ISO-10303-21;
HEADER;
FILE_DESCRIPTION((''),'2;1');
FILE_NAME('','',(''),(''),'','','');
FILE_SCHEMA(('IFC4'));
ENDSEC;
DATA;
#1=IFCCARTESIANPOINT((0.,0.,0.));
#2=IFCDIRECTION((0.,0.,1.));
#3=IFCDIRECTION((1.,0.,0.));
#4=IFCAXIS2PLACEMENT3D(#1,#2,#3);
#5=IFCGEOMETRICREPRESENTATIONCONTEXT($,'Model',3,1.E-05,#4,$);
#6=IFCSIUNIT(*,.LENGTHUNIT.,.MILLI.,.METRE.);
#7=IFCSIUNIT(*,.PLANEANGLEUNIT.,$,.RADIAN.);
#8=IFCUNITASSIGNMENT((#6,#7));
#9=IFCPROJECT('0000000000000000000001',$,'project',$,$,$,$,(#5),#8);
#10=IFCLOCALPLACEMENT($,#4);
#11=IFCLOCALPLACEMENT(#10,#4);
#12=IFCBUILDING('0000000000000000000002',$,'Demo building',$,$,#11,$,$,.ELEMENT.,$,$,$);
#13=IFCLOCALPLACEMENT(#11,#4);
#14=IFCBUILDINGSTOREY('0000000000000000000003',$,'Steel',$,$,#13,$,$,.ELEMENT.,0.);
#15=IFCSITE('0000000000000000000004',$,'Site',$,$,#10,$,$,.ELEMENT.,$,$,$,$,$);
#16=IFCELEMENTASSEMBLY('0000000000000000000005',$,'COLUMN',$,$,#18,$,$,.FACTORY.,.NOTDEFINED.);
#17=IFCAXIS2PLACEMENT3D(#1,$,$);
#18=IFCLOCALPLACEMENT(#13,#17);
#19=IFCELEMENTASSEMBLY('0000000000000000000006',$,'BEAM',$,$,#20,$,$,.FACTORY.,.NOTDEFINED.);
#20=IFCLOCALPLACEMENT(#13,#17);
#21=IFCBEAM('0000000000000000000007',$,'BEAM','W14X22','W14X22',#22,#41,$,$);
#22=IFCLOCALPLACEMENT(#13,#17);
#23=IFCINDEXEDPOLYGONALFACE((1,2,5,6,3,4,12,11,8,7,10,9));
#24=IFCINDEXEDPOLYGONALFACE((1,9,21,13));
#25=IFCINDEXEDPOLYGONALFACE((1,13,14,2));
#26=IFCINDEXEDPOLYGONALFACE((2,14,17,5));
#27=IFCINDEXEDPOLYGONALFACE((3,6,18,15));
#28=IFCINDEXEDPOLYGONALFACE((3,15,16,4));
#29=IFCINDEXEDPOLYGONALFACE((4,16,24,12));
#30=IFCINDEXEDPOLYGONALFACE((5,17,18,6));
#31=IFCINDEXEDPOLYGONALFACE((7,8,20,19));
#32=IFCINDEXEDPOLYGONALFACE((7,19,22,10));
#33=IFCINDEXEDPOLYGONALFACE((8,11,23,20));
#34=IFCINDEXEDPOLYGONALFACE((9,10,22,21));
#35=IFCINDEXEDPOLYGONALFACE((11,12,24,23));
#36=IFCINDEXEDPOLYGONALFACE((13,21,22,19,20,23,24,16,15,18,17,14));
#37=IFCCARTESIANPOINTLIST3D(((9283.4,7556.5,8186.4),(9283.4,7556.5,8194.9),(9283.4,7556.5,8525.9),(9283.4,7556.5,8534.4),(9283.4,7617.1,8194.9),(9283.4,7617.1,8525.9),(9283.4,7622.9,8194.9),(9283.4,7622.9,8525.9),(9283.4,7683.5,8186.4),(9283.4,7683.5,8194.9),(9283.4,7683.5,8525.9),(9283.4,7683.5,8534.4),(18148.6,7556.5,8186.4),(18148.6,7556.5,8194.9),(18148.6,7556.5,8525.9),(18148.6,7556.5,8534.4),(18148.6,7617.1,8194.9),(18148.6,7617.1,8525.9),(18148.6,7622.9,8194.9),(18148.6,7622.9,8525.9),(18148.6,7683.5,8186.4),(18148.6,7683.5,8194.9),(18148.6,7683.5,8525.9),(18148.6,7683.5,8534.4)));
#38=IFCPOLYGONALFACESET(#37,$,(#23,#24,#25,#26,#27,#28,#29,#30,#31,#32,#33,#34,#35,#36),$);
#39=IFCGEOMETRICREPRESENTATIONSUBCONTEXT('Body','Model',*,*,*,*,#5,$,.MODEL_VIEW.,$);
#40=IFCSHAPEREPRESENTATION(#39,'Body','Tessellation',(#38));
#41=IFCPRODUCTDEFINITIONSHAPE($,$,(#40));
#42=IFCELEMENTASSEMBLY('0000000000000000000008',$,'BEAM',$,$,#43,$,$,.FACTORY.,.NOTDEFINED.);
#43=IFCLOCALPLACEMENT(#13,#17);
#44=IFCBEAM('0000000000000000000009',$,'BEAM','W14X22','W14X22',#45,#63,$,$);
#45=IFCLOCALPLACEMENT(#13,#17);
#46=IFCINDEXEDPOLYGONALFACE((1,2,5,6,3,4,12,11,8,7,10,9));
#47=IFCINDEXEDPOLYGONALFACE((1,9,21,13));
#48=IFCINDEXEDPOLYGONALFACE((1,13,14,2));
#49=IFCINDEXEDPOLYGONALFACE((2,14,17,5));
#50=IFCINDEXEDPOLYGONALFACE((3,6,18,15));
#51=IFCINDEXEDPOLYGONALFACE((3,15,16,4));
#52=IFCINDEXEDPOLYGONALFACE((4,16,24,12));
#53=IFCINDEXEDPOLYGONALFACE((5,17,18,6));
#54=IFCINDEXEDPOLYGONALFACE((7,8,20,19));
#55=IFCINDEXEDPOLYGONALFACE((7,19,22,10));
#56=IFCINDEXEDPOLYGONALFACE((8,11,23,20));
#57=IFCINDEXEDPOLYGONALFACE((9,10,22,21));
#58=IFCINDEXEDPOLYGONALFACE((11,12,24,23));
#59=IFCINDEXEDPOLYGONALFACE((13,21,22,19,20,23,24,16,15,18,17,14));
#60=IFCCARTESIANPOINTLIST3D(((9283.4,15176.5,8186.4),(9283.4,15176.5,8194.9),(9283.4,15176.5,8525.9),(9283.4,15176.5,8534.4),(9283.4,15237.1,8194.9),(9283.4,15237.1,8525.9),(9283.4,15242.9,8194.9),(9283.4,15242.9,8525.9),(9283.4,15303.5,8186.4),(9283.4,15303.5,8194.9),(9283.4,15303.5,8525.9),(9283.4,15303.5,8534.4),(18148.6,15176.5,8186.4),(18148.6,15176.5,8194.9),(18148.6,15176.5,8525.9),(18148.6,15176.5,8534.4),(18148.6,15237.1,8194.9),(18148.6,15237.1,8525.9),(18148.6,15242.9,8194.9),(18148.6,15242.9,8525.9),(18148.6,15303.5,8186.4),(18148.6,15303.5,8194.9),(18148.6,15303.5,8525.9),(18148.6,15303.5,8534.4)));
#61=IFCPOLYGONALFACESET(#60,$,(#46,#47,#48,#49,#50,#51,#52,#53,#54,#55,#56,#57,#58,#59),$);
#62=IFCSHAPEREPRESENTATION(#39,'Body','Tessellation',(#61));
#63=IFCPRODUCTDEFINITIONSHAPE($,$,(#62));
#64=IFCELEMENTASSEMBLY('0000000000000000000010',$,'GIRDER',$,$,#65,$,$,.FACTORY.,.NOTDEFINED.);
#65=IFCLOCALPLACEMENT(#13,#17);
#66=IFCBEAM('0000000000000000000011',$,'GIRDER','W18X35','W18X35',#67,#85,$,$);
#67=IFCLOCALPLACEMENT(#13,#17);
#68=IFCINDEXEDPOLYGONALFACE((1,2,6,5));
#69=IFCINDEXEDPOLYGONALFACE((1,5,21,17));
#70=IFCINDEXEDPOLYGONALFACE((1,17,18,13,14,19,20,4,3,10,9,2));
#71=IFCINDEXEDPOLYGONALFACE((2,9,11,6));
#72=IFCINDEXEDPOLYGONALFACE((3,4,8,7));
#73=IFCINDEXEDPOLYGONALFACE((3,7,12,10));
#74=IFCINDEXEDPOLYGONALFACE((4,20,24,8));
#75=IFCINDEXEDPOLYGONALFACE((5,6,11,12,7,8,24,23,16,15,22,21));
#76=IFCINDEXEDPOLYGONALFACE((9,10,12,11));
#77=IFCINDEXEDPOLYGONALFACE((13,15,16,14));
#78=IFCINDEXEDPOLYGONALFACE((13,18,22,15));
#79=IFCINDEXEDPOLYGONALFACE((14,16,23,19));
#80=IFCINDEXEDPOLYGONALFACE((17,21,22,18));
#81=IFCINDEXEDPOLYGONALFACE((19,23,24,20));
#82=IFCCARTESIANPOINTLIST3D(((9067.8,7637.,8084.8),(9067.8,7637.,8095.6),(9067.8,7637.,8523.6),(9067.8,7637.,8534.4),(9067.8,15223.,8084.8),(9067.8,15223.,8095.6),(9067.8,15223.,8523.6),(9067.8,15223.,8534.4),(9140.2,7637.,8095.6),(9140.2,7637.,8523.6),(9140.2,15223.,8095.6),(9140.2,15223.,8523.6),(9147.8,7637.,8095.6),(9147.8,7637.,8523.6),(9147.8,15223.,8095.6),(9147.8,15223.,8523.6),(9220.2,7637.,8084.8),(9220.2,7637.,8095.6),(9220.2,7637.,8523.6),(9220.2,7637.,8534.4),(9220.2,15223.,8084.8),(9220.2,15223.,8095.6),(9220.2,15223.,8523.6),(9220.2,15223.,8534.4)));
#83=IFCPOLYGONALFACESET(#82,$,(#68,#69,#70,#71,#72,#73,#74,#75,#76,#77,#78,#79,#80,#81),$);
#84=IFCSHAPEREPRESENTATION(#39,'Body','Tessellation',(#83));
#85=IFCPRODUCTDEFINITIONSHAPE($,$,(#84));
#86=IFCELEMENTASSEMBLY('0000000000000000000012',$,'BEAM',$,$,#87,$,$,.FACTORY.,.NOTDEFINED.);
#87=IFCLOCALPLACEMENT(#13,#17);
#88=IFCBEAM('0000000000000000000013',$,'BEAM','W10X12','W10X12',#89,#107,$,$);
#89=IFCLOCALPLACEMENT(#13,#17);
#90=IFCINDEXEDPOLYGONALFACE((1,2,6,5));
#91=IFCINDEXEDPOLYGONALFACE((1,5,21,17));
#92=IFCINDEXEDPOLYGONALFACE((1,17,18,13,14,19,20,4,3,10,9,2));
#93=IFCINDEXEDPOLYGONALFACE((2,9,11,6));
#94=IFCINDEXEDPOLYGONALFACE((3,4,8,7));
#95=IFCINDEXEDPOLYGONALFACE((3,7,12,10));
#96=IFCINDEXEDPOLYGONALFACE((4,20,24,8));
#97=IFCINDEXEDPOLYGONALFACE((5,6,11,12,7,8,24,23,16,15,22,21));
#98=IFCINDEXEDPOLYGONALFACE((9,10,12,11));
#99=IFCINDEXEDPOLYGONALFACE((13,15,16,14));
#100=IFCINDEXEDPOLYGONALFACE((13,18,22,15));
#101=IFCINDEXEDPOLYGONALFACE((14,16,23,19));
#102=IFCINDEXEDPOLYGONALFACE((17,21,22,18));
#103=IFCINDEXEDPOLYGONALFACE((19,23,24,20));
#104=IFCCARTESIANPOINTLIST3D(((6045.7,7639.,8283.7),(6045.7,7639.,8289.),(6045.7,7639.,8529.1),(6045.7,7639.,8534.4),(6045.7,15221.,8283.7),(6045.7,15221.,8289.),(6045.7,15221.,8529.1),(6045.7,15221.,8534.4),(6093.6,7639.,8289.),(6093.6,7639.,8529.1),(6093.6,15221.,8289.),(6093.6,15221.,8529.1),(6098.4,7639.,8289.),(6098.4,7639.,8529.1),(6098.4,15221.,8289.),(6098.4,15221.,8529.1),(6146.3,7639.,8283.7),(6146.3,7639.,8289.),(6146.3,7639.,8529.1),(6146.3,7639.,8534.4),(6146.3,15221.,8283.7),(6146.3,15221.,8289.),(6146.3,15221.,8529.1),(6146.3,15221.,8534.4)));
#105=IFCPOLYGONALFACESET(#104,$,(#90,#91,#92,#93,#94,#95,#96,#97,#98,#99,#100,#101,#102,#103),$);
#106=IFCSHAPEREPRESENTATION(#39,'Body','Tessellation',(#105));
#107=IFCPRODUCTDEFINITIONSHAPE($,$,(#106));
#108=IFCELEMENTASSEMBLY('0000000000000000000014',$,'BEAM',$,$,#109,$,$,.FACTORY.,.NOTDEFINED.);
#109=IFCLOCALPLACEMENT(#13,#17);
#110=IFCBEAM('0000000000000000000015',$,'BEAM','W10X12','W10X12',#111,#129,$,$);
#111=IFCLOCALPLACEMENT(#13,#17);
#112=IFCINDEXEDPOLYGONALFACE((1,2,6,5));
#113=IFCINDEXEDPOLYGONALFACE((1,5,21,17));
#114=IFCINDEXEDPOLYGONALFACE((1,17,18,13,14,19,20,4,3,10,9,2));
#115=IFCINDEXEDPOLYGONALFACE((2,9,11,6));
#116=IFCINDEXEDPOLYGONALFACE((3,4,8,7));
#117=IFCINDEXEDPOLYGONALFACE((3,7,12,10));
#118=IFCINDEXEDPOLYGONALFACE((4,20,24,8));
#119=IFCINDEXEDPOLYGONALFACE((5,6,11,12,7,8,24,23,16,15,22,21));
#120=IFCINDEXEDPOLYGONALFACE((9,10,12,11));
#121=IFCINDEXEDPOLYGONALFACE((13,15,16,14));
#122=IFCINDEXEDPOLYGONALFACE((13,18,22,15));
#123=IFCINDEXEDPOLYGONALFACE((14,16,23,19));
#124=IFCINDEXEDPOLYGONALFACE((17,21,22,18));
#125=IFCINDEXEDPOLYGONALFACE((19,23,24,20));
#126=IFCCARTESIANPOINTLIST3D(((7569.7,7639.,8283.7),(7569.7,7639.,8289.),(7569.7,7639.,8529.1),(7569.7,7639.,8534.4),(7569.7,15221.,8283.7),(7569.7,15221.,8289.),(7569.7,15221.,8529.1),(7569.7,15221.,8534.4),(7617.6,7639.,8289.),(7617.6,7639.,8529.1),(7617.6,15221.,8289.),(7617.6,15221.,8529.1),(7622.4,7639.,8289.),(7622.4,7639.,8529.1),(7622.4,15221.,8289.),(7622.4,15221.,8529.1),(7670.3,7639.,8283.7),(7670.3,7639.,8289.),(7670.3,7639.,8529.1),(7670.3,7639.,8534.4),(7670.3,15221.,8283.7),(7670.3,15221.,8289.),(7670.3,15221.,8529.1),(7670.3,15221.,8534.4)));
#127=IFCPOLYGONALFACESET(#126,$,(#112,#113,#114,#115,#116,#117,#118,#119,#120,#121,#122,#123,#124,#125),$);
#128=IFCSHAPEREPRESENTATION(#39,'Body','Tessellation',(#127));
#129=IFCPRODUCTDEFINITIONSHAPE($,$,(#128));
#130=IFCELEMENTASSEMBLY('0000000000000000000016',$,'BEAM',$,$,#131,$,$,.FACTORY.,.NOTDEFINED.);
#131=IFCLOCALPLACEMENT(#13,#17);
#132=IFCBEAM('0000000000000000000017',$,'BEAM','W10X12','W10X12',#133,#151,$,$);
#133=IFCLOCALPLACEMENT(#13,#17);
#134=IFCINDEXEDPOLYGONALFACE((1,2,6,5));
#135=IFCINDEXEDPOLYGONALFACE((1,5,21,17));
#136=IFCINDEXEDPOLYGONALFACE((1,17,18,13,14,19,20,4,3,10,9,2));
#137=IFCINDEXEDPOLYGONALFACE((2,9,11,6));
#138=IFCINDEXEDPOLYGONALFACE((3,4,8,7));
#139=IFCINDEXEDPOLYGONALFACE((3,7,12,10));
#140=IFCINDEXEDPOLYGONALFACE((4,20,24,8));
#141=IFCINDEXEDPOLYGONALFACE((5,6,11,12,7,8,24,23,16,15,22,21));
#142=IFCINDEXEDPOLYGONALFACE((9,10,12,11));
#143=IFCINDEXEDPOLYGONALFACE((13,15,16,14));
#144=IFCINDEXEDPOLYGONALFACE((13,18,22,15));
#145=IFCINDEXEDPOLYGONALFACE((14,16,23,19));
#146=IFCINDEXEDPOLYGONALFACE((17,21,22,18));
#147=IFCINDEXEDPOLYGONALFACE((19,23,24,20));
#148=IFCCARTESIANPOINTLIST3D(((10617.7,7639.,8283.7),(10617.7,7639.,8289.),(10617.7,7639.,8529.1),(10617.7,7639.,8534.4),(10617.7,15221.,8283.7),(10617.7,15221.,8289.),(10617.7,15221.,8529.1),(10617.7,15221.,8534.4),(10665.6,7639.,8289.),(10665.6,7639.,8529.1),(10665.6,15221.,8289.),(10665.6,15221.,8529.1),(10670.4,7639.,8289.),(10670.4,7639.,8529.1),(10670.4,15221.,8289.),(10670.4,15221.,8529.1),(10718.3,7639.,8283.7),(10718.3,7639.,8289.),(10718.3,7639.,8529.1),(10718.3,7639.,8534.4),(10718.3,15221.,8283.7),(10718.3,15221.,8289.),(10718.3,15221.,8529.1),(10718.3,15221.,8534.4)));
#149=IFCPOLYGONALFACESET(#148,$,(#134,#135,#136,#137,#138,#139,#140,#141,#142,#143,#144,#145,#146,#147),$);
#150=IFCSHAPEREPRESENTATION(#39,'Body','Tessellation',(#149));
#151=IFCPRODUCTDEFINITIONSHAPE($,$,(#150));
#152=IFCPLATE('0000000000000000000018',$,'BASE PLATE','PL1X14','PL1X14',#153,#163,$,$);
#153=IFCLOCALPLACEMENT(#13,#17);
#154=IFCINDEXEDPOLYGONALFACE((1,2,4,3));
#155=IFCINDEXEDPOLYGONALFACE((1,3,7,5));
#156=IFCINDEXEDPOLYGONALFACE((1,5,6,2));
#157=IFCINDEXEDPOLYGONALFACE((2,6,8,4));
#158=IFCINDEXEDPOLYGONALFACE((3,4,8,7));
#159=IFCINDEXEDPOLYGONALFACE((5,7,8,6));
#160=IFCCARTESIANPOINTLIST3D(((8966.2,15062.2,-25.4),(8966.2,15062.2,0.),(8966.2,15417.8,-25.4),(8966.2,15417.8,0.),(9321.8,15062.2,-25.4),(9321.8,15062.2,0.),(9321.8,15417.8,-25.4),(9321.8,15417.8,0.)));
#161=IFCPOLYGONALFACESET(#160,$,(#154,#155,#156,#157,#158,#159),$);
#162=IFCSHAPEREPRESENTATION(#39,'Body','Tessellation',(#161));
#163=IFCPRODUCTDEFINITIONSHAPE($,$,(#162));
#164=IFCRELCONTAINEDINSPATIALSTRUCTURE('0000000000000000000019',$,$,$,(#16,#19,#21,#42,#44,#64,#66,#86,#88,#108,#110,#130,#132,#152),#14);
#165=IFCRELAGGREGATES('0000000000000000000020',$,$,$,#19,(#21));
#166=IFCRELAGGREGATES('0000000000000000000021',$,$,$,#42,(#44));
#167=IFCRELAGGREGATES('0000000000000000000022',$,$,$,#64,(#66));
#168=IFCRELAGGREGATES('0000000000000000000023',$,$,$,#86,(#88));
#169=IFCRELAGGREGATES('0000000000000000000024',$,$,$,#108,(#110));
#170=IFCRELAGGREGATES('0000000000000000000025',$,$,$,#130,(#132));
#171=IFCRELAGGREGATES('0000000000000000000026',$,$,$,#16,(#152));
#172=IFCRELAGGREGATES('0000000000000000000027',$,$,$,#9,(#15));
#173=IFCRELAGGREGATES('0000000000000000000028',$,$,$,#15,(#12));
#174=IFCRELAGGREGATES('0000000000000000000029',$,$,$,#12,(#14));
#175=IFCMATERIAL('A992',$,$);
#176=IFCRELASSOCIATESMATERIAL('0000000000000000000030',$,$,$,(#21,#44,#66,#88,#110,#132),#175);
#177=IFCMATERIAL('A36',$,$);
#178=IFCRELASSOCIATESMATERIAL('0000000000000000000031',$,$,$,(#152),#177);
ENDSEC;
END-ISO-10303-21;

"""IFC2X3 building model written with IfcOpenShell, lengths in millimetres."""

from ifc_helpers import new_model, si_unit, frame, frame_2d, origin, origin_with_axes, origin_2d, place, context, subcontext, project, spatial, rectangle, i_section, extrude, material, element, aggregate, save


model = new_model("IFC2X3")

# Units and contexts
model_context = context("Model", 3, precision=1e-05, world=origin_with_axes())
body_context = subcontext(model_context, "Body", "Model", "MODEL_VIEW")
ifc_project = project(units=[si_unit("LENGTHUNIT", "METRE", prefix="MILLI"), si_unit("PLANEANGLEUNIT", "RADIAN")], contexts=[model_context])

# Site, building, storey
site_placement = place(None, origin_with_axes())
site = spatial("IfcSite", under=ifc_project, at=site_placement, Name="Site", CompositionType="ELEMENT")
building_placement = place(site_placement, origin_with_axes())
building = spatial("IfcBuilding", under=site, at=building_placement, Name="Demo building", CompositionType="ELEMENT")
placement = place(building_placement, origin_with_axes())
storey = spatial("IfcBuildingStorey", under=building, at=placement, Name="Steel", CompositionType="ELEMENT", Elevation=0.0)

# Element assembly
ifc_material_1 = material(Name="A992")
assembly_1 = element("IfcElementAssembly", 1, at=placement, inside=storey, Name="COLUMN", AssemblyPlace="FACTORY", PredefinedType="NOTDEFINED")

# Element assemblies, beams
assembly_2 = element("IfcElementAssembly", 2, at=placement, inside=storey, Name="BEAM", AssemblyPlace="FACTORY", PredefinedType="NOTDEFINED")
beam_1_placement = place(placement, frame((9283.4, 7620.0, 8360.4), z_axis=(1.0, 0.0, 0.0), x_axis=(0.0, 1.0, 0.0)))
beam_1 = element("IfcBeam", 3, at=beam_1_placement, inside=storey, material=ifc_material_1, Name="BEAM", Description="W14X22", ObjectType="W14X22", context=body_context, shape_type="SweptSolid", body=[
    extrude(i_section(OverallWidth=127.0, OverallDepth=348.0, WebThickness=5.8, FlangeThickness=8.5, at=origin_2d()), origin(), (0.0, 0.0, 1.0), 8865.1),
])
aggregate(assembly_2, [beam_1])
assembly_3 = element("IfcElementAssembly", 4, at=placement, inside=storey, Name="BEAM", AssemblyPlace="FACTORY", PredefinedType="NOTDEFINED")
beam_2_placement = place(placement, frame((9283.4, 15240.0, 8360.4), z_axis=(1.0, 0.0, 0.0), x_axis=(0.0, 1.0, 0.0)))
beam_2 = element("IfcBeam", 5, at=beam_2_placement, inside=storey, material=ifc_material_1, Name="BEAM", Description="W14X22", ObjectType="W14X22", context=body_context, shape_type="SweptSolid", body=[
    extrude(i_section(OverallWidth=127.0, OverallDepth=348.0, WebThickness=5.8, FlangeThickness=8.5, at=origin_2d()), origin(), (0.0, 0.0, 1.0), 8865.1),
])
aggregate(assembly_3, [beam_2])
assembly_4 = element("IfcElementAssembly", 6, at=placement, inside=storey, Name="GIRDER", AssemblyPlace="FACTORY", PredefinedType="NOTDEFINED")
beam_3_placement = place(placement, frame((9144.0, 7637.0, 8309.6), z_axis=(0.0, 1.0, 0.0), x_axis=(-1.0, 0.0, 0.0)))
beam_3 = element("IfcBeam", 7, at=beam_3_placement, inside=storey, material=ifc_material_1, Name="GIRDER", Description="W18X35", ObjectType="W18X35", context=body_context, shape_type="SweptSolid", body=[
    extrude(i_section(OverallWidth=152.4, OverallDepth=449.6, WebThickness=7.6, FlangeThickness=10.8, at=origin_2d()), origin(), (0.0, 0.0, 1.0), 7586.0),
])
aggregate(assembly_4, [beam_3])
assembly_5 = element("IfcElementAssembly", 8, at=placement, inside=storey, Name="BEAM", AssemblyPlace="FACTORY", PredefinedType="NOTDEFINED")
beam_4_placement = place(placement, frame((6096.0, 7639.1, 8409.1), z_axis=(0.0, 1.0, 0.0), x_axis=(-1.0, 0.0, 0.0)))
beam_4 = element("IfcBeam", 9, at=beam_4_placement, inside=storey, material=ifc_material_1, Name="BEAM", Description="W10X12", ObjectType="W10X12", context=body_context, shape_type="SweptSolid", body=[
    extrude(i_section(OverallWidth=100.6, OverallDepth=250.7, WebThickness=4.8, FlangeThickness=5.3, at=origin_2d()), origin(), (0.0, 0.0, 1.0), 7581.9),
])
aggregate(assembly_5, [beam_4])
assembly_6 = element("IfcElementAssembly", 10, at=placement, inside=storey, Name="BEAM", AssemblyPlace="FACTORY", PredefinedType="NOTDEFINED")
beam_5_placement = place(placement, frame((7620.0, 7639.1, 8409.1), z_axis=(0.0, 1.0, 0.0), x_axis=(-1.0, 0.0, 0.0)))
beam_5 = element("IfcBeam", 11, at=beam_5_placement, inside=storey, material=ifc_material_1, Name="BEAM", Description="W10X12", ObjectType="W10X12", context=body_context, shape_type="SweptSolid", body=[
    extrude(i_section(OverallWidth=100.6, OverallDepth=250.7, WebThickness=4.8, FlangeThickness=5.3, at=origin_2d()), origin(), (0.0, 0.0, 1.0), 7581.9),
])
aggregate(assembly_6, [beam_5])
assembly_7 = element("IfcElementAssembly", 12, at=placement, inside=storey, Name="BEAM", AssemblyPlace="FACTORY", PredefinedType="NOTDEFINED")
beam_6_placement = place(placement, frame((10668.0, 7639.1, 8409.1), z_axis=(0.0, 1.0, 0.0), x_axis=(-1.0, 0.0, 0.0)))
beam_6 = element("IfcBeam", 13, at=beam_6_placement, inside=storey, material=ifc_material_1, Name="BEAM", Description="W10X12", ObjectType="W10X12", context=body_context, shape_type="SweptSolid", body=[
    extrude(i_section(OverallWidth=100.6, OverallDepth=250.7, WebThickness=4.8, FlangeThickness=5.3, at=origin_2d()), origin(), (0.0, 0.0, 1.0), 7581.9),
])
aggregate(assembly_7, [beam_6])

# Plate
ifc_material_2 = material(Name="A36")
plate_1_placement = place(placement, frame((8966.2, 15062.2, -25.4), z_axis=(0.0, 0.0, 1.0), x_axis=(1.0, 0.0, 0.0)))
plate_1 = element("IfcPlate", 14, at=plate_1_placement, inside=storey, material=ifc_material_2, Name="BASE PLATE", Description="PL1X14", ObjectType="PL1X14", context=body_context, shape_type="SweptSolid", body=[
    extrude(rectangle(XDim=355.6, YDim=355.6, at=frame_2d((177.8, 177.8))), origin(), (0.0, 0.0, 1.0), 25.4),
])
aggregate(assembly_1, [plate_1])

save(model, "model.ifc")
